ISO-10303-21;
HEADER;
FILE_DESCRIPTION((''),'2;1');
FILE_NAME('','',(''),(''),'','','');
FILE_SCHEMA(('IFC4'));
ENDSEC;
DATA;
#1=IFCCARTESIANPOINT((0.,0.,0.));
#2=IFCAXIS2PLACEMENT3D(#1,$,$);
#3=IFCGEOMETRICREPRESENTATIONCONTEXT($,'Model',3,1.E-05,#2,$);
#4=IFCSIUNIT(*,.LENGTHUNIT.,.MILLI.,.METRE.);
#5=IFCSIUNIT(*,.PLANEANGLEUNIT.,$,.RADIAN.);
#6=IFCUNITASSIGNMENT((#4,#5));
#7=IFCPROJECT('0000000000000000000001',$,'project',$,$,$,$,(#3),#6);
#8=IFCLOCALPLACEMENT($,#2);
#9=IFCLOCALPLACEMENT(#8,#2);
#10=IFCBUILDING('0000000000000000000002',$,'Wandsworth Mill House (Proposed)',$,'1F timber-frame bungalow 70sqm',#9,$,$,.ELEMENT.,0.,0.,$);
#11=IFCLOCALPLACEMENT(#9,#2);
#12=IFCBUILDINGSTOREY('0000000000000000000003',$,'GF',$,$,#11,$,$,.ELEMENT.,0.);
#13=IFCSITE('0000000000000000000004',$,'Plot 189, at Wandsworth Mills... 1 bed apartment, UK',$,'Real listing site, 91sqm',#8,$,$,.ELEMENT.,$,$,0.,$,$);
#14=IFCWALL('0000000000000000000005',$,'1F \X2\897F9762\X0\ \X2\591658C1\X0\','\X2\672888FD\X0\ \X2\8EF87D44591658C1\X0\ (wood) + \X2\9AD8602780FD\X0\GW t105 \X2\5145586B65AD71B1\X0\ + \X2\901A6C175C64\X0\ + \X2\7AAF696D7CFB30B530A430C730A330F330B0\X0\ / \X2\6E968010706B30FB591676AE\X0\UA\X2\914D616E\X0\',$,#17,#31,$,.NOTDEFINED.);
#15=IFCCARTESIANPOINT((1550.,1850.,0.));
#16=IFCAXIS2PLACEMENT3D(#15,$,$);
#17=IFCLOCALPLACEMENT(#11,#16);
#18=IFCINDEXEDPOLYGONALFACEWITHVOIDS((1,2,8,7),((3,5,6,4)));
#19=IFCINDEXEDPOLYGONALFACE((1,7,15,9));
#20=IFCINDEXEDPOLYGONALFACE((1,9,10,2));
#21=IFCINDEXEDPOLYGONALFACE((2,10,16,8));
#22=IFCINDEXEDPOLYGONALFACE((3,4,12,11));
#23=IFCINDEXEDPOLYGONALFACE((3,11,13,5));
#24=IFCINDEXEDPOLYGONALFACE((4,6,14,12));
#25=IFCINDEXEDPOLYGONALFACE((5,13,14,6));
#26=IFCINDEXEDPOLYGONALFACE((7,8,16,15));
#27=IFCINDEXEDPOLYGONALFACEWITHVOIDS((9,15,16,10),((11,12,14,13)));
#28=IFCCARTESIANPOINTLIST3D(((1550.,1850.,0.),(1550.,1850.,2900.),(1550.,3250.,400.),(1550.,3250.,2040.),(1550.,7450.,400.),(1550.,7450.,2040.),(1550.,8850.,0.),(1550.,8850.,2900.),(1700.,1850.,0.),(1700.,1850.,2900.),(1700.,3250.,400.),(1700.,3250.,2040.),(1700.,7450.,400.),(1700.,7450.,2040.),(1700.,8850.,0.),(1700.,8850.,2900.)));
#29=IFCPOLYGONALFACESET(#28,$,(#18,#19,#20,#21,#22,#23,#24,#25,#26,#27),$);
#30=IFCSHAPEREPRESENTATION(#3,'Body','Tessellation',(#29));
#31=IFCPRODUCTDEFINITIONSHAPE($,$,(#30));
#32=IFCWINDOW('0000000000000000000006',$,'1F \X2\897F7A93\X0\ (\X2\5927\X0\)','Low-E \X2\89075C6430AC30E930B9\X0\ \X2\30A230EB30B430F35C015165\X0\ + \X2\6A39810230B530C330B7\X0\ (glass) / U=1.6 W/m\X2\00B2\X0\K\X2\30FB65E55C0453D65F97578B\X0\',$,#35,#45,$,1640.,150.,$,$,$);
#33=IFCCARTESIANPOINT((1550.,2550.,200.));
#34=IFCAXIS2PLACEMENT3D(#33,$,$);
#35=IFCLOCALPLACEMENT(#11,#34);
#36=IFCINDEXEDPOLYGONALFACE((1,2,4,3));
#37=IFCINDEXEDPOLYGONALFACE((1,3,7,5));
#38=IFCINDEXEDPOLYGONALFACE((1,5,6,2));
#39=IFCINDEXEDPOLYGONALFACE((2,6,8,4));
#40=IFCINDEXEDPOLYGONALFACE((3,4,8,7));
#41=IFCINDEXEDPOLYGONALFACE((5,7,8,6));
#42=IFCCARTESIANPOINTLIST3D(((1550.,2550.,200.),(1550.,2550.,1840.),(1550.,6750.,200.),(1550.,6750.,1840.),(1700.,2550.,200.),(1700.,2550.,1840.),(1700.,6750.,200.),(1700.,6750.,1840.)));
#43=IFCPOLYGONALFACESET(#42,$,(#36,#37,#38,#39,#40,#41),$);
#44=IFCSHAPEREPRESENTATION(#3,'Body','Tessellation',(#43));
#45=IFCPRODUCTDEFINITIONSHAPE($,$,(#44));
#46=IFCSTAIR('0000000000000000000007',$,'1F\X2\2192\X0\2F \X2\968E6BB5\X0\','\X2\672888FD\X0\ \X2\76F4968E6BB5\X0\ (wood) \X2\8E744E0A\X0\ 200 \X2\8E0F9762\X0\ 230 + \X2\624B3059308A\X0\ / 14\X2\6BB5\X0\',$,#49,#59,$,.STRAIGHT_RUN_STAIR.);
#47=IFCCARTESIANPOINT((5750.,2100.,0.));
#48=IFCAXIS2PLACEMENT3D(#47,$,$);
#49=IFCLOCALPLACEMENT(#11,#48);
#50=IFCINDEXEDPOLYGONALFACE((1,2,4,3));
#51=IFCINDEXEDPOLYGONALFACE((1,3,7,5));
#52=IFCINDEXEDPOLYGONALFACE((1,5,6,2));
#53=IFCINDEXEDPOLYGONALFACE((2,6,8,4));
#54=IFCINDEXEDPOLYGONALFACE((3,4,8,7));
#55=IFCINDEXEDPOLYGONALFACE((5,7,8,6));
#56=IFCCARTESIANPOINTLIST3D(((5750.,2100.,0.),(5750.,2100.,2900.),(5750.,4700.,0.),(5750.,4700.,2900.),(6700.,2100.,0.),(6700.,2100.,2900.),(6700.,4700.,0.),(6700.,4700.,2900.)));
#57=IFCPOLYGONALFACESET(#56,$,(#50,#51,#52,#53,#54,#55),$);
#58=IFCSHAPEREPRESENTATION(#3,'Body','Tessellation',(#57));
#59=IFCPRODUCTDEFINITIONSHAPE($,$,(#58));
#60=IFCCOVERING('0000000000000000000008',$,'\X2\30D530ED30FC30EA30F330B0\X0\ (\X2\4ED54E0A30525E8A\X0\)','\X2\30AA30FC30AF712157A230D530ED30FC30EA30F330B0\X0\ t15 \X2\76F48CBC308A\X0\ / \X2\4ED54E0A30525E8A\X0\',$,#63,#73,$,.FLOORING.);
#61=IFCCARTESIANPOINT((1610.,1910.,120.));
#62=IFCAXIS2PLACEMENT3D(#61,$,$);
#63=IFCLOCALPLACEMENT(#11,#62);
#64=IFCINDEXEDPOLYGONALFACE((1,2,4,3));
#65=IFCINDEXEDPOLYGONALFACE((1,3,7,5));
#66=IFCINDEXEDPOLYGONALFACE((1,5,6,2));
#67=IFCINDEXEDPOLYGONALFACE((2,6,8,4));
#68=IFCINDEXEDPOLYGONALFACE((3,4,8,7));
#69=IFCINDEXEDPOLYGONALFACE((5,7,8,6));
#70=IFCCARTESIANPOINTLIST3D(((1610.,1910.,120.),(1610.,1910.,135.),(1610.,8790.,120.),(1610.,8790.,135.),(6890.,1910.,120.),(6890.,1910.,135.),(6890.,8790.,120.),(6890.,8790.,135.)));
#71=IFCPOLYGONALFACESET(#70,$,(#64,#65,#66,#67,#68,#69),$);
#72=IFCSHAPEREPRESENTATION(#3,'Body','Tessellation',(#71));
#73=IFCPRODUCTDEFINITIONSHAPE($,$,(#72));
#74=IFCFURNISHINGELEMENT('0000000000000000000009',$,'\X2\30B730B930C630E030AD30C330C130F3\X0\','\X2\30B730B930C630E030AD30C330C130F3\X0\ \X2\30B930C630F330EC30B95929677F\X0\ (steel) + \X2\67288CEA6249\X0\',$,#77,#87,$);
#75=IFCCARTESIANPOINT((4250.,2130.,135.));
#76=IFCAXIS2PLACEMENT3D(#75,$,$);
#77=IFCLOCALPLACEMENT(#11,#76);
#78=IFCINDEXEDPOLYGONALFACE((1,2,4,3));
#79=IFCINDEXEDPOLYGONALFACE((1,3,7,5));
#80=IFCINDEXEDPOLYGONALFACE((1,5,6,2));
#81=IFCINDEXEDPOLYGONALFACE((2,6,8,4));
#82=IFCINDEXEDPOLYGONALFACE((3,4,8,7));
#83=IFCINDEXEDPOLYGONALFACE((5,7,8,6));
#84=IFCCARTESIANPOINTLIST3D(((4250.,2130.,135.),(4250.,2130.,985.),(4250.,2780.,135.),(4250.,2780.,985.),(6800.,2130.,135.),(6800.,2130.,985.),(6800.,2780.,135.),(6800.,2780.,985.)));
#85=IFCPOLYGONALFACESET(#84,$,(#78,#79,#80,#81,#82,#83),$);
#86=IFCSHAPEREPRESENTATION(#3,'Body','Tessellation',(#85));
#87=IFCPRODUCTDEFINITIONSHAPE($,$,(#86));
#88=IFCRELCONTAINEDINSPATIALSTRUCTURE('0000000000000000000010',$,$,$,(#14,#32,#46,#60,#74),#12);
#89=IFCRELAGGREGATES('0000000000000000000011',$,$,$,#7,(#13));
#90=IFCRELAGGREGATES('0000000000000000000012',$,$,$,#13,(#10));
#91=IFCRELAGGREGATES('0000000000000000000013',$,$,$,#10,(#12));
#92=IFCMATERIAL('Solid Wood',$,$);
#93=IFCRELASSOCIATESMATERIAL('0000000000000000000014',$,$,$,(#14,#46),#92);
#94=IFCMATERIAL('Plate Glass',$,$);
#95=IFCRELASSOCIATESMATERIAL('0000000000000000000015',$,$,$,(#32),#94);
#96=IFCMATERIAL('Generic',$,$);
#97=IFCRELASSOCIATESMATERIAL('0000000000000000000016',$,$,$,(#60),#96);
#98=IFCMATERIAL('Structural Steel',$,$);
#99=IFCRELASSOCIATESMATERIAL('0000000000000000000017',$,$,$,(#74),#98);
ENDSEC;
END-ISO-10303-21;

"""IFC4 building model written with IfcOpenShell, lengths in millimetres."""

from ifc_helpers import new_model, si_unit, frame, frame_2d, origin, place, context, project, spatial, rectangle, extrude, material, element, fill, save


model = new_model("IFC4")

# Units and contexts
model_context = context("Model", 3, precision=1e-05, world=origin())
ifc_project = project(units=[si_unit("LENGTHUNIT", "METRE", prefix="MILLI"), si_unit("PLANEANGLEUNIT", "RADIAN")], contexts=[model_context])

# Site, building, storey
site_placement = place(None, origin())
site = spatial("IfcSite", under=ifc_project, at=site_placement, Name="Plot 189, at Wandsworth Mills... 1 bed apartment, UK", ObjectType="Real listing site, 91sqm", CompositionType="ELEMENT", RefElevation=0.0)
building_placement = place(site_placement, origin())
building = spatial("IfcBuilding", under=site, at=building_placement, Name="Wandsworth Mill House (Proposed)", ObjectType="1F timber-frame bungalow 70sqm", CompositionType="ELEMENT", ElevationOfRefHeight=0.0, ElevationOfTerrain=0.0)
storey_placement = place(building_placement, origin())
storey = spatial("IfcBuildingStorey", under=building, at=storey_placement, Name="GF", CompositionType="ELEMENT", Elevation=0.0)

# Shared definitions
ifc_material_1 = material(Name="Solid Wood")
ifc_material_2 = material(Name="Generic")

# Shared definitions
ifc_material_3 = material(Name="Plate Glass")

# Wall, opening, window
wall_1_placement = place(storey_placement, frame((1550.0, 1850.0, 0.0)))
wall_1 = element("IfcWall", 1, at=wall_1_placement, inside=storey, material=ifc_material_1, Name="1F 西面 外壁", Description="木製 軸組外壁 (wood) + 高性能GW t105 充填断熱 + 通気層 + 窯業系サイディング / 準耐火・外皮UA配慮", PredefinedType="NOTDEFINED", context=model_context, shape_type="SweptSolid", body=[
    extrude(rectangle(XDim=150.0, YDim=7000.0, at=frame_2d((75.0, 3500.0))), frame((1550.0, 1850.0, 0.0)), (0.0, 0.0, 1.0), 2900.0),
])
opening_1_placement = place(storey_placement, frame((1550.0, 2550.0, 200.0)))
opening_1 = element("IfcOpeningElement", 2, at=opening_1_placement, cuts=wall_1, PredefinedType="NOTDEFINED", context=model_context, shape_type="SweptSolid", body=[
    extrude(rectangle(XDim=150.0, YDim=4200.0, at=frame_2d((75.0, 2100.0))), frame((1550.0, 2550.0, 200.0)), (0.0, 0.0, 1.0), 1640.0),
])
window_1_placement = place(storey_placement, frame((1550.0, 2550.0, 200.0)))
window_1 = element("IfcWindow", 3, at=window_1_placement, inside=storey, material=ifc_material_3, Name="1F 西窓 (大)", Description="Low-E 複層ガラス アルゴン封入 + 樹脂サッシ (glass) / U=1.6 W/m²K・日射取得型", OverallHeight=1640.0, OverallWidth=150.0, context=model_context, shape_type="SweptSolid", body=[
    extrude(rectangle(XDim=150.0, YDim=4200.0, at=frame_2d((75.0, 2100.0))), frame((1550.0, 2550.0, 200.0)), (0.0, 0.0, 1.0), 1640.0),
])
fill(opening_1, window_1)

# Stair
stair_placement = place(storey_placement, frame((5750.0, 2100.0, 0.0)))
element("IfcStair", 4, at=stair_placement, inside=storey, material=ifc_material_1, Name="1F→2F 階段", Description="木製 直階段 (wood) 蹴上 200 踏面 230 + 手すり / 14段", PredefinedType="STRAIGHT_RUN_STAIR", context=model_context, shape_type="SweptSolid", body=[
    extrude(rectangle(XDim=950.0, YDim=2600.0, at=frame_2d((475.0, 1300.0))), frame((5750.0, 2100.0, 0.0)), (0.0, 0.0, 1.0), 2900.0),
])

# Covering
covering_placement = place(storey_placement, frame((1610.0, 1910.0, 120.0)))
element("IfcCovering", 5, at=covering_placement, inside=storey, material=ifc_material_2, Name="フローリング (仕上げ床)", Description="オーク無垢フローリング t15 直貼り / 仕上げ床", PredefinedType="FLOORING", context=model_context, shape_type="SweptSolid", body=[
    extrude(rectangle(XDim=5280.0, YDim=6880.0, at=frame_2d((2640.0, 3440.0))), frame((1610.0, 1910.0, 120.0)), (0.0, 0.0, 1.0), 15.0),
])

# Furnishing element
ifc_material_4 = material(Name="Structural Steel")
furnishing_placement = place(storey_placement, frame((4250.0, 2130.0, 135.0)))
element("IfcFurnishingElement", 6, at=furnishing_placement, inside=storey, material=ifc_material_4, Name="システムキッチン", Description="システムキッチン ステンレス天板 (steel) + 木質扉", context=model_context, shape_type="SweptSolid", body=[
    extrude(rectangle(XDim=2550.0, YDim=650.0, at=frame_2d((1275.0, 325.0))), frame((4250.0, 2130.0, 135.0)), (0.0, 0.0, 1.0), 850.0),
])

save(model, "model.ifc")
